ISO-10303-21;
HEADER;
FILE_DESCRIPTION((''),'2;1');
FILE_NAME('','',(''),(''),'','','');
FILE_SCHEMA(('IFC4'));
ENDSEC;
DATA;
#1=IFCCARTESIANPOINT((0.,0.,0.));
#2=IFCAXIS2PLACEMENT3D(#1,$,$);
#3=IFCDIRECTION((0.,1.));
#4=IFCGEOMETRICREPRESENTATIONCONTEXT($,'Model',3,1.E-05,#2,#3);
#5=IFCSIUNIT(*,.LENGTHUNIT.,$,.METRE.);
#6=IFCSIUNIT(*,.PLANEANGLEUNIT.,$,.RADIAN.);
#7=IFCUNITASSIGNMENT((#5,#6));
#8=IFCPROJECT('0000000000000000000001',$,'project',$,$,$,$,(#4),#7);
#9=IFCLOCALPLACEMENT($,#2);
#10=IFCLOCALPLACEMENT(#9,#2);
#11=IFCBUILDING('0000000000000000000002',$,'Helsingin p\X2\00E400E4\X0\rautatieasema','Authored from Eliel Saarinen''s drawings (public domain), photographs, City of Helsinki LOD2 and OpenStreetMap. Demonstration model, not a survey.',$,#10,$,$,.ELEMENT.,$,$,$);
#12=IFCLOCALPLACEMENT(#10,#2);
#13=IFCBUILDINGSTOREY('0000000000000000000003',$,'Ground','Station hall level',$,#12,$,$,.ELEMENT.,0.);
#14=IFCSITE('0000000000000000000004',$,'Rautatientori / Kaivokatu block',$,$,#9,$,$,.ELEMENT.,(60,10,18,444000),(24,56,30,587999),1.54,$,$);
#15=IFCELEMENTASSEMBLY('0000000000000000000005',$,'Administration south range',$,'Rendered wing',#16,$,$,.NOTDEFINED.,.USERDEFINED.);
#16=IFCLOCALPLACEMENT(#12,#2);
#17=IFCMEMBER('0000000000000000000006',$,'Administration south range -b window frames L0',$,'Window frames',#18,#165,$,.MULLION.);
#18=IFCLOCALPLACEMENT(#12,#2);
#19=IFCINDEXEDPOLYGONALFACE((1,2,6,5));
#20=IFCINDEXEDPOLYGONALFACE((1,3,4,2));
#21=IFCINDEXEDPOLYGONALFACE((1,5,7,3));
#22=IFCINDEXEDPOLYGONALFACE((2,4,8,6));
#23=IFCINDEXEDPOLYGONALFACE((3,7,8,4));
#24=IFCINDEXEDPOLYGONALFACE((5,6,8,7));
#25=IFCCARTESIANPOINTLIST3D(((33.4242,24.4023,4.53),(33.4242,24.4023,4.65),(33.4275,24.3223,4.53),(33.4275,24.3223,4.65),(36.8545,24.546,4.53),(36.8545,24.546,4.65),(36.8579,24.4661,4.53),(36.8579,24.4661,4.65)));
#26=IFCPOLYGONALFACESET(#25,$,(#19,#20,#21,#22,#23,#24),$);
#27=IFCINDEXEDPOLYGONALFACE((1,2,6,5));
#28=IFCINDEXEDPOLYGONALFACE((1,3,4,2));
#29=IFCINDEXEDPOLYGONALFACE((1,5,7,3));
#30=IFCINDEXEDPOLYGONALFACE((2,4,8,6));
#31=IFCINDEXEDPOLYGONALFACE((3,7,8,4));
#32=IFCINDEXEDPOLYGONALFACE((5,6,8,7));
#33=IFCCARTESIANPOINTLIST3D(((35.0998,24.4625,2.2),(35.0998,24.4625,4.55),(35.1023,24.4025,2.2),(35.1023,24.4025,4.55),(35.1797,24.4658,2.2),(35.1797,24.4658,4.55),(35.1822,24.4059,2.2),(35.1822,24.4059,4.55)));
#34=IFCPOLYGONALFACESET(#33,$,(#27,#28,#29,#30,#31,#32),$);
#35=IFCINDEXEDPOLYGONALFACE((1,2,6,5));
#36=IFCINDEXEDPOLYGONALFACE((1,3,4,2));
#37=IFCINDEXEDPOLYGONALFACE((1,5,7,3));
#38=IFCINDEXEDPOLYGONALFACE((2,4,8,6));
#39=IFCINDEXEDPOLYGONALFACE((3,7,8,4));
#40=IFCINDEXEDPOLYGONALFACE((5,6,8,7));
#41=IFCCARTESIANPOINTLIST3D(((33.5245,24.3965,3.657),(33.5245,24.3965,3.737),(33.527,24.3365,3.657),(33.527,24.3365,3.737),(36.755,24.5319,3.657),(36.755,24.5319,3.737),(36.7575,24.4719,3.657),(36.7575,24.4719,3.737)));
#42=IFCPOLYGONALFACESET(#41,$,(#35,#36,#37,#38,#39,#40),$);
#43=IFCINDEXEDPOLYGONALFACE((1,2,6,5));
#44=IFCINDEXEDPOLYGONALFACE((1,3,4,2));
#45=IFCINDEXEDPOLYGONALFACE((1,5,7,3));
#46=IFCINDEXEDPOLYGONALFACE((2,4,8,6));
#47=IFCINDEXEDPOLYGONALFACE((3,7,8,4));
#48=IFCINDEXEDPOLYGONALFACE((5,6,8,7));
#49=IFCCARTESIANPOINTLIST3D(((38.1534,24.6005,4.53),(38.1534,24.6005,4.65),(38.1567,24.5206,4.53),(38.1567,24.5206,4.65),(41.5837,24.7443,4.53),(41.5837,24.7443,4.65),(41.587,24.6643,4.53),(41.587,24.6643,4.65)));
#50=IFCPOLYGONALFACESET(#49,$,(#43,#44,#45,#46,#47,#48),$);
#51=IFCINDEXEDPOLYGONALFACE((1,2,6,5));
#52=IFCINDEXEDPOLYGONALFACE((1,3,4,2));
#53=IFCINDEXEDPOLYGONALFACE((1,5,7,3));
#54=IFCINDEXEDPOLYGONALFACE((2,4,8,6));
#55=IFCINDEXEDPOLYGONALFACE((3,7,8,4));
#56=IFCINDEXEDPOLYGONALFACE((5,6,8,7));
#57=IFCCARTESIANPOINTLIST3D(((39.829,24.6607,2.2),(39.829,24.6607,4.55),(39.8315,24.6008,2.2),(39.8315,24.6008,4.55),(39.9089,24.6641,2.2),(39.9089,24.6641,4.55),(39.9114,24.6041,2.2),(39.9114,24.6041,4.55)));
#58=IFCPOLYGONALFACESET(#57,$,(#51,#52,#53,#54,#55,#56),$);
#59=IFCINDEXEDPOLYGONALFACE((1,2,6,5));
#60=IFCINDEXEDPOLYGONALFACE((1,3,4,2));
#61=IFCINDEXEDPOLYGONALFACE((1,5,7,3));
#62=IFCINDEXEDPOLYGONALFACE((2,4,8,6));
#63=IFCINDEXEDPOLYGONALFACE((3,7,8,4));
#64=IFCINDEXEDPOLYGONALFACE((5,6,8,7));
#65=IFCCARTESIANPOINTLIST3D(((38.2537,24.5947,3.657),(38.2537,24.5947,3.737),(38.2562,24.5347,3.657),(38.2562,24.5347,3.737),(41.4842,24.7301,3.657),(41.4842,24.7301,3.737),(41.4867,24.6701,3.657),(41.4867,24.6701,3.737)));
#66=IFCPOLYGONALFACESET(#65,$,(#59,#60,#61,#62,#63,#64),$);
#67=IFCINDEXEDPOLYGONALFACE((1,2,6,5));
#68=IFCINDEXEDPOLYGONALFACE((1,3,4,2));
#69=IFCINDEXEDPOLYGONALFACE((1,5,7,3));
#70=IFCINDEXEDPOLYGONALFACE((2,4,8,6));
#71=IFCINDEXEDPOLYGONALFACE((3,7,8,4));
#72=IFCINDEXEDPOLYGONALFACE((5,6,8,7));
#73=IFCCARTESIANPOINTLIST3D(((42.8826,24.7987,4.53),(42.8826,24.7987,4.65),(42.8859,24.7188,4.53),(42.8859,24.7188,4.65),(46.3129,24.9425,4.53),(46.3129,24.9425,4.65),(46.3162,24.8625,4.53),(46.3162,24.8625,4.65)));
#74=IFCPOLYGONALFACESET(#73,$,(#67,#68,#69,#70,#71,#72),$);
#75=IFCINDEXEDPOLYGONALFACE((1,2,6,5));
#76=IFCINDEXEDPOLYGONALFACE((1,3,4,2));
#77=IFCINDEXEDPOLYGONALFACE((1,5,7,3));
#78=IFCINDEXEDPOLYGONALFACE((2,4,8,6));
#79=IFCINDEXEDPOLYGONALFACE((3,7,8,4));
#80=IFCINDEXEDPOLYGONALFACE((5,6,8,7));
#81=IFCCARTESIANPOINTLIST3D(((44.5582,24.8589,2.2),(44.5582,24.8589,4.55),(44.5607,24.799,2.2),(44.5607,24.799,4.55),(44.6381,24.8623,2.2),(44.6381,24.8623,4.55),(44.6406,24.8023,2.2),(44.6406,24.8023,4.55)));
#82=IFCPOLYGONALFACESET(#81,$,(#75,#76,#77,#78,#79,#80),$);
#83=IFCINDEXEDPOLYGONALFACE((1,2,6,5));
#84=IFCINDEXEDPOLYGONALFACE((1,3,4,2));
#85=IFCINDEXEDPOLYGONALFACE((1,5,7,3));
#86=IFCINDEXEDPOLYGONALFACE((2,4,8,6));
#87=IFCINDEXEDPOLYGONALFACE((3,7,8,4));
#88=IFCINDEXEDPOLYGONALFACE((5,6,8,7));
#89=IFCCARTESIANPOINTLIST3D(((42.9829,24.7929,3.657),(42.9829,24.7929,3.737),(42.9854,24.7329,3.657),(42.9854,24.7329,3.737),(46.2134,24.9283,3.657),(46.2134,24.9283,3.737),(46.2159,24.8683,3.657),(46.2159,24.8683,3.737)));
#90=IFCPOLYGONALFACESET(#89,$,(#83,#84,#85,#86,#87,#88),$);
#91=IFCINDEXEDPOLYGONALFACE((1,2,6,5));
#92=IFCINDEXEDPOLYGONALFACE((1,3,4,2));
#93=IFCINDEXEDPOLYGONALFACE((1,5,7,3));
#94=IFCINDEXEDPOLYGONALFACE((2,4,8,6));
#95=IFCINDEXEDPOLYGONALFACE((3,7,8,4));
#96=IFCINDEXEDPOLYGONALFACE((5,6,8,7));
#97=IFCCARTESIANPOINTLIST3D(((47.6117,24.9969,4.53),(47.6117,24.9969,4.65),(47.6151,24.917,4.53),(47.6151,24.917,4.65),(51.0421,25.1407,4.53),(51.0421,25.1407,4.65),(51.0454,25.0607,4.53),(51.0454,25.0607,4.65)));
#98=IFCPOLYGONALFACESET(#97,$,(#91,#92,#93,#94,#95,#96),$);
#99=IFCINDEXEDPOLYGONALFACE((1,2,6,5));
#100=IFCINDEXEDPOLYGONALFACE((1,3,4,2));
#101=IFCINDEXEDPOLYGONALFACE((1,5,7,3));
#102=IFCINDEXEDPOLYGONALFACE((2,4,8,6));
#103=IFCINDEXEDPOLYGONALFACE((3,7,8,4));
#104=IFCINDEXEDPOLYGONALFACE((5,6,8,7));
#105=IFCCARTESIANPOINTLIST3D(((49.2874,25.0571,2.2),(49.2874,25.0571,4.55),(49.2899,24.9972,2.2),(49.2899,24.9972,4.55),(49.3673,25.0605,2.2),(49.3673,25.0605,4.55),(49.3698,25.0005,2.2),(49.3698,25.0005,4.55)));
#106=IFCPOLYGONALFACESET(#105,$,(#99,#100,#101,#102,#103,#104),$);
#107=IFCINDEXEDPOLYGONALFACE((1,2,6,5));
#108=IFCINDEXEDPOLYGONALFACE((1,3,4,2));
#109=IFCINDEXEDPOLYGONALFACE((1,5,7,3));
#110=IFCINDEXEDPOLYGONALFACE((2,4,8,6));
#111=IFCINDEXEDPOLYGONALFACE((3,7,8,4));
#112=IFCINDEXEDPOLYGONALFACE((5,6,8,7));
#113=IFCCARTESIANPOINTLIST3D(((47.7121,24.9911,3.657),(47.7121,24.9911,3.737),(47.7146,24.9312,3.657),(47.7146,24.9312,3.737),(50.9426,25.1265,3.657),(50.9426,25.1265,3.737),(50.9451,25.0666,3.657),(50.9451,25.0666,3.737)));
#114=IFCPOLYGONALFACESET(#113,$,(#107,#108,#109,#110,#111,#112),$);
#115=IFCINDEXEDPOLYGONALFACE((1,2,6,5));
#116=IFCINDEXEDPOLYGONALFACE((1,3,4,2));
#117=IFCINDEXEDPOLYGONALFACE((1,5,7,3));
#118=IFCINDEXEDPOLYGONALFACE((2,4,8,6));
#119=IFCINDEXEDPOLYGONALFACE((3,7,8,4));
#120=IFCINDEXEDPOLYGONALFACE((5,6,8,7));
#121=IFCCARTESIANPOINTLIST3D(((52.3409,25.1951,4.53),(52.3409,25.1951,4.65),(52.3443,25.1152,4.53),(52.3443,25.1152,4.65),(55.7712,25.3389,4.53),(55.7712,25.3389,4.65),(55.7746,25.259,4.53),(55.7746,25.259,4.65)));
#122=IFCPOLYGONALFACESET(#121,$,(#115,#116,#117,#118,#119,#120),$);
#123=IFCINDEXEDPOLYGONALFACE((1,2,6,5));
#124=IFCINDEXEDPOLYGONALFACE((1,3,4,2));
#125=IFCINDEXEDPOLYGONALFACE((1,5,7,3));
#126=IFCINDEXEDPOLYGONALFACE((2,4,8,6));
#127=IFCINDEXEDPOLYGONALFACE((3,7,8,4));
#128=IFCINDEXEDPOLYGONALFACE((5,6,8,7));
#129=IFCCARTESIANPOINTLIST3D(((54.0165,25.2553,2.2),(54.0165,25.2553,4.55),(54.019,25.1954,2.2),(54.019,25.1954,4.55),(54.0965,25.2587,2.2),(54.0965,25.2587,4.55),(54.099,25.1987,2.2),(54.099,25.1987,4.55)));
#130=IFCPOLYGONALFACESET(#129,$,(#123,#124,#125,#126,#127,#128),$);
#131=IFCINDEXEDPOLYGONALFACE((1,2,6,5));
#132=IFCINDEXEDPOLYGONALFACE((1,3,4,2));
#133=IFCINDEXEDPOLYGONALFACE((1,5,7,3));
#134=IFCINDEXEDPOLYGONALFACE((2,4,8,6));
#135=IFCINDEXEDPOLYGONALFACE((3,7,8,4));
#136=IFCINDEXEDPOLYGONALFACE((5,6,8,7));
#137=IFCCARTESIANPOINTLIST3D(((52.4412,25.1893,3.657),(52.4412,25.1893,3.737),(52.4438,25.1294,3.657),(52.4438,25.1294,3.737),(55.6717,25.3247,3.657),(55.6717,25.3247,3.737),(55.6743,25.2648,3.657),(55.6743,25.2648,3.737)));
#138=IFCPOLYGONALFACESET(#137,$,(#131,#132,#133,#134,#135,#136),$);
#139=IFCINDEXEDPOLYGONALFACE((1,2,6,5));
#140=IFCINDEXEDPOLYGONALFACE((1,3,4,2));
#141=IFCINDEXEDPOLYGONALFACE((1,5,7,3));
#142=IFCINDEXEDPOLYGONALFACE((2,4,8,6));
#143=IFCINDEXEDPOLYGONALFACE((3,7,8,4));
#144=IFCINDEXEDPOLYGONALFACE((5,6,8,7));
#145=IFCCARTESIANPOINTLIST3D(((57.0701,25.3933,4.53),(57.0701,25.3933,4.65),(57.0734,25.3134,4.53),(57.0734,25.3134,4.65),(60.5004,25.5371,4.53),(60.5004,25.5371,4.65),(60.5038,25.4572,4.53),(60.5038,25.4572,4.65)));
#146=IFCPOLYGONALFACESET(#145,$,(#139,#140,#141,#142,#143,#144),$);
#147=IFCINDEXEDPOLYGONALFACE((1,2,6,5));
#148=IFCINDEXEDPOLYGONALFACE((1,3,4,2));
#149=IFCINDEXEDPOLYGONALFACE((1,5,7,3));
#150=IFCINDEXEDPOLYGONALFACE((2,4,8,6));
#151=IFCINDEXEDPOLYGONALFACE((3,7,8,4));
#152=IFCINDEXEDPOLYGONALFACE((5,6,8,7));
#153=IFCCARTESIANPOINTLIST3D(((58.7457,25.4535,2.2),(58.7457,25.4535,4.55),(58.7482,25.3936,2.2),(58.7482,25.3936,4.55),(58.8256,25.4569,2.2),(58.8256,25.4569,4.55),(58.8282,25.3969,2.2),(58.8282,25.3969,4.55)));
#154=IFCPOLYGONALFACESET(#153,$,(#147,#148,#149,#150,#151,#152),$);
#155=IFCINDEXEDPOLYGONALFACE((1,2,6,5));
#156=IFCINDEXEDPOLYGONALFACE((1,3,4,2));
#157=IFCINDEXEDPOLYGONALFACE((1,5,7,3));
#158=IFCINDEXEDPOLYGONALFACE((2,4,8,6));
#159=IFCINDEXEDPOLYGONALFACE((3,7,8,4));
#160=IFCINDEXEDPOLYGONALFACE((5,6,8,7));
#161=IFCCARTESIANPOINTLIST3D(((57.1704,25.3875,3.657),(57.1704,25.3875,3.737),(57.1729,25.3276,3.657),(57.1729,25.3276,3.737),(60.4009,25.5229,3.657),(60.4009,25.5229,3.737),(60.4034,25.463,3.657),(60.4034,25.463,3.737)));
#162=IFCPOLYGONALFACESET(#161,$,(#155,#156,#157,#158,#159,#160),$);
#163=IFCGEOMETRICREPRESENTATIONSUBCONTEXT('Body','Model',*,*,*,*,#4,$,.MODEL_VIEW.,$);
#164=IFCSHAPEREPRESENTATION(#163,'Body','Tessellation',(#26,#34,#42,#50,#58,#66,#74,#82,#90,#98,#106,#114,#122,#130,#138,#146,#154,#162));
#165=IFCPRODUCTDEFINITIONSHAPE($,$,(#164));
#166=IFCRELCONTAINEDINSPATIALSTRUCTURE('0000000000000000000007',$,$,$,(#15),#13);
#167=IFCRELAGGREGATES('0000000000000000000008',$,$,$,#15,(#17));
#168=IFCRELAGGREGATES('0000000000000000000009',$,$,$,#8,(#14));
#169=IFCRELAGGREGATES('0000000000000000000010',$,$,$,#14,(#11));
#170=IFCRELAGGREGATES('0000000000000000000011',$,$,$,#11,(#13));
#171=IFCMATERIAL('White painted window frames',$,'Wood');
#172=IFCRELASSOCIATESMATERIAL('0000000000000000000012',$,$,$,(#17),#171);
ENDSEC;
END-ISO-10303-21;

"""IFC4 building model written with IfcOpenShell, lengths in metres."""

from ifc_helpers import new_model, si_unit, direction, frame, frame_2d, origin, place, context, subcontext, project, spatial, rectangle, extrude, material, element, aggregate, save


model = new_model("IFC4")

# Units and contexts
model_context = context("Model", 3, precision=1e-05, world=origin(), true_north=direction((0.0, 1.0)))
body_context = subcontext(model_context, "Body", "Model", "MODEL_VIEW")
ifc_project = project(units=[si_unit("LENGTHUNIT", "METRE"), si_unit("PLANEANGLEUNIT", "RADIAN")], contexts=[model_context])

# Site, building, storey
site_placement = place(None, origin())
site = spatial("IfcSite", under=ifc_project, at=site_placement, Name="Rautatientori / Kaivokatu block", CompositionType="ELEMENT", RefLatitude=(60, 10, 18, 444000), RefLongitude=(24, 56, 30, 587999), RefElevation=1.54)
building_placement = place(site_placement, origin())
building = spatial("IfcBuilding", under=site, at=building_placement, Name="Helsingin päärautatieasema", Description="Authored from Eliel Saarinen's drawings (public domain), photographs, City of Helsinki LOD2 and OpenStreetMap. Demonstration model, not a survey.", CompositionType="ELEMENT")
storey_placement = place(building_placement, origin())
storey = spatial("IfcBuildingStorey", under=building, at=storey_placement, Name="Ground", Description="Station hall level", CompositionType="ELEMENT", Elevation=0.0)

# Element assembly, member
assembly_1_placement = place(building_placement, origin())
assembly_1 = element("IfcElementAssembly", 1, at=assembly_1_placement, inside=storey, Name="Administration south range", ObjectType="Rendered wing", AssemblyPlace="NOTDEFINED", PredefinedType="USERDEFINED")
ifc_material_1 = material(Name="White painted window frames", Category="Wood")
member_1_placement = place(building_placement, origin())
member_1 = element("IfcMember", 2, at=member_1_placement, material=ifc_material_1, Name="Administration south range -b window frames L0", ObjectType="Window frames", PredefinedType="MULLION", context=body_context, shape_type="SweptSolid", body=[
    extrude(rectangle(XDim=3.4333, YDim=0.08, at=frame_2d((0.0, 0.0), x_axis=(0.999123, 0.041876))), frame((35.141, 24.4342, 4.53)), (0.0, 0.0, 1.0), 0.12),
    extrude(rectangle(XDim=0.08, YDim=0.06, at=frame_2d((0.0, 0.0), x_axis=(0.999123, 0.041876))), frame((35.141, 24.4342, 2.2)), (0.0, 0.0, 1.0), 2.35),
    extrude(rectangle(XDim=3.2333, YDim=0.06, at=frame_2d((0.0, 0.0), x_axis=(0.999123, 0.041876))), frame((35.141, 24.4342, 3.657)), (0.0, 0.0, 1.0), 0.08),
    extrude(rectangle(XDim=3.4333, YDim=0.08, at=frame_2d((0.0, 0.0), x_axis=(0.999123, 0.041876))), frame((39.8702, 24.6324, 4.53)), (0.0, 0.0, 1.0), 0.12),
    extrude(rectangle(XDim=0.08, YDim=0.06, at=frame_2d((0.0, 0.0), x_axis=(0.999123, 0.041876))), frame((39.8702, 24.6324, 2.2)), (0.0, 0.0, 1.0), 2.35),
    extrude(rectangle(XDim=3.2333, YDim=0.06, at=frame_2d((0.0, 0.0), x_axis=(0.999123, 0.041876))), frame((39.8702, 24.6324, 3.657)), (0.0, 0.0, 1.0), 0.08),
    extrude(rectangle(XDim=3.4333, YDim=0.08, at=frame_2d((0.0, 0.0), x_axis=(0.999123, 0.041876))), frame((44.5994, 24.8306, 4.53)), (0.0, 0.0, 1.0), 0.12),
    extrude(rectangle(XDim=0.08, YDim=0.06, at=frame_2d((0.0, 0.0), x_axis=(0.999123, 0.041876))), frame((44.5994, 24.8306, 2.2)), (0.0, 0.0, 1.0), 2.35),
    extrude(rectangle(XDim=3.2333, YDim=0.06, at=frame_2d((0.0, 0.0), x_axis=(0.999123, 0.041876))), frame((44.5994, 24.8306, 3.657)), (0.0, 0.0, 1.0), 0.08),
    extrude(rectangle(XDim=3.4333, YDim=0.08, at=frame_2d((0.0, 0.0), x_axis=(0.999123, 0.041876))), frame((49.3286, 25.0288, 4.53)), (0.0, 0.0, 1.0), 0.12),
    extrude(rectangle(XDim=0.08, YDim=0.06, at=frame_2d((0.0, 0.0), x_axis=(0.999123, 0.041876))), frame((49.3286, 25.0288, 2.2)), (0.0, 0.0, 1.0), 2.35),
    extrude(rectangle(XDim=3.2333, YDim=0.06, at=frame_2d((0.0, 0.0), x_axis=(0.999123, 0.041876))), frame((49.3286, 25.0288, 3.657)), (0.0, 0.0, 1.0), 0.08),
    extrude(rectangle(XDim=3.4333, YDim=0.08, at=frame_2d((0.0, 0.0), x_axis=(0.999123, 0.041876))), frame((54.0578, 25.227, 4.53)), (0.0, 0.0, 1.0), 0.12),
    extrude(rectangle(XDim=0.08, YDim=0.06, at=frame_2d((0.0, 0.0), x_axis=(0.999123, 0.041876))), frame((54.0578, 25.227, 2.2)), (0.0, 0.0, 1.0), 2.35),
    extrude(rectangle(XDim=3.2333, YDim=0.06, at=frame_2d((0.0, 0.0), x_axis=(0.999123, 0.041876))), frame((54.0578, 25.227, 3.657)), (0.0, 0.0, 1.0), 0.08),
    extrude(rectangle(XDim=3.4333, YDim=0.08, at=frame_2d((0.0, 0.0), x_axis=(0.999123, 0.041876))), frame((58.7869, 25.4252, 4.53)), (0.0, 0.0, 1.0), 0.12),
    extrude(rectangle(XDim=0.08, YDim=0.06, at=frame_2d((0.0, 0.0), x_axis=(0.999123, 0.041876))), frame((58.7869, 25.4252, 2.2)), (0.0, 0.0, 1.0), 2.35),
    extrude(rectangle(XDim=3.2333, YDim=0.06, at=frame_2d((0.0, 0.0), x_axis=(0.999123, 0.041876))), frame((58.7869, 25.4252, 3.657)), (0.0, 0.0, 1.0), 0.08),
])

aggregate(assembly_1, [member_1])

save(model, "model.ifc")
